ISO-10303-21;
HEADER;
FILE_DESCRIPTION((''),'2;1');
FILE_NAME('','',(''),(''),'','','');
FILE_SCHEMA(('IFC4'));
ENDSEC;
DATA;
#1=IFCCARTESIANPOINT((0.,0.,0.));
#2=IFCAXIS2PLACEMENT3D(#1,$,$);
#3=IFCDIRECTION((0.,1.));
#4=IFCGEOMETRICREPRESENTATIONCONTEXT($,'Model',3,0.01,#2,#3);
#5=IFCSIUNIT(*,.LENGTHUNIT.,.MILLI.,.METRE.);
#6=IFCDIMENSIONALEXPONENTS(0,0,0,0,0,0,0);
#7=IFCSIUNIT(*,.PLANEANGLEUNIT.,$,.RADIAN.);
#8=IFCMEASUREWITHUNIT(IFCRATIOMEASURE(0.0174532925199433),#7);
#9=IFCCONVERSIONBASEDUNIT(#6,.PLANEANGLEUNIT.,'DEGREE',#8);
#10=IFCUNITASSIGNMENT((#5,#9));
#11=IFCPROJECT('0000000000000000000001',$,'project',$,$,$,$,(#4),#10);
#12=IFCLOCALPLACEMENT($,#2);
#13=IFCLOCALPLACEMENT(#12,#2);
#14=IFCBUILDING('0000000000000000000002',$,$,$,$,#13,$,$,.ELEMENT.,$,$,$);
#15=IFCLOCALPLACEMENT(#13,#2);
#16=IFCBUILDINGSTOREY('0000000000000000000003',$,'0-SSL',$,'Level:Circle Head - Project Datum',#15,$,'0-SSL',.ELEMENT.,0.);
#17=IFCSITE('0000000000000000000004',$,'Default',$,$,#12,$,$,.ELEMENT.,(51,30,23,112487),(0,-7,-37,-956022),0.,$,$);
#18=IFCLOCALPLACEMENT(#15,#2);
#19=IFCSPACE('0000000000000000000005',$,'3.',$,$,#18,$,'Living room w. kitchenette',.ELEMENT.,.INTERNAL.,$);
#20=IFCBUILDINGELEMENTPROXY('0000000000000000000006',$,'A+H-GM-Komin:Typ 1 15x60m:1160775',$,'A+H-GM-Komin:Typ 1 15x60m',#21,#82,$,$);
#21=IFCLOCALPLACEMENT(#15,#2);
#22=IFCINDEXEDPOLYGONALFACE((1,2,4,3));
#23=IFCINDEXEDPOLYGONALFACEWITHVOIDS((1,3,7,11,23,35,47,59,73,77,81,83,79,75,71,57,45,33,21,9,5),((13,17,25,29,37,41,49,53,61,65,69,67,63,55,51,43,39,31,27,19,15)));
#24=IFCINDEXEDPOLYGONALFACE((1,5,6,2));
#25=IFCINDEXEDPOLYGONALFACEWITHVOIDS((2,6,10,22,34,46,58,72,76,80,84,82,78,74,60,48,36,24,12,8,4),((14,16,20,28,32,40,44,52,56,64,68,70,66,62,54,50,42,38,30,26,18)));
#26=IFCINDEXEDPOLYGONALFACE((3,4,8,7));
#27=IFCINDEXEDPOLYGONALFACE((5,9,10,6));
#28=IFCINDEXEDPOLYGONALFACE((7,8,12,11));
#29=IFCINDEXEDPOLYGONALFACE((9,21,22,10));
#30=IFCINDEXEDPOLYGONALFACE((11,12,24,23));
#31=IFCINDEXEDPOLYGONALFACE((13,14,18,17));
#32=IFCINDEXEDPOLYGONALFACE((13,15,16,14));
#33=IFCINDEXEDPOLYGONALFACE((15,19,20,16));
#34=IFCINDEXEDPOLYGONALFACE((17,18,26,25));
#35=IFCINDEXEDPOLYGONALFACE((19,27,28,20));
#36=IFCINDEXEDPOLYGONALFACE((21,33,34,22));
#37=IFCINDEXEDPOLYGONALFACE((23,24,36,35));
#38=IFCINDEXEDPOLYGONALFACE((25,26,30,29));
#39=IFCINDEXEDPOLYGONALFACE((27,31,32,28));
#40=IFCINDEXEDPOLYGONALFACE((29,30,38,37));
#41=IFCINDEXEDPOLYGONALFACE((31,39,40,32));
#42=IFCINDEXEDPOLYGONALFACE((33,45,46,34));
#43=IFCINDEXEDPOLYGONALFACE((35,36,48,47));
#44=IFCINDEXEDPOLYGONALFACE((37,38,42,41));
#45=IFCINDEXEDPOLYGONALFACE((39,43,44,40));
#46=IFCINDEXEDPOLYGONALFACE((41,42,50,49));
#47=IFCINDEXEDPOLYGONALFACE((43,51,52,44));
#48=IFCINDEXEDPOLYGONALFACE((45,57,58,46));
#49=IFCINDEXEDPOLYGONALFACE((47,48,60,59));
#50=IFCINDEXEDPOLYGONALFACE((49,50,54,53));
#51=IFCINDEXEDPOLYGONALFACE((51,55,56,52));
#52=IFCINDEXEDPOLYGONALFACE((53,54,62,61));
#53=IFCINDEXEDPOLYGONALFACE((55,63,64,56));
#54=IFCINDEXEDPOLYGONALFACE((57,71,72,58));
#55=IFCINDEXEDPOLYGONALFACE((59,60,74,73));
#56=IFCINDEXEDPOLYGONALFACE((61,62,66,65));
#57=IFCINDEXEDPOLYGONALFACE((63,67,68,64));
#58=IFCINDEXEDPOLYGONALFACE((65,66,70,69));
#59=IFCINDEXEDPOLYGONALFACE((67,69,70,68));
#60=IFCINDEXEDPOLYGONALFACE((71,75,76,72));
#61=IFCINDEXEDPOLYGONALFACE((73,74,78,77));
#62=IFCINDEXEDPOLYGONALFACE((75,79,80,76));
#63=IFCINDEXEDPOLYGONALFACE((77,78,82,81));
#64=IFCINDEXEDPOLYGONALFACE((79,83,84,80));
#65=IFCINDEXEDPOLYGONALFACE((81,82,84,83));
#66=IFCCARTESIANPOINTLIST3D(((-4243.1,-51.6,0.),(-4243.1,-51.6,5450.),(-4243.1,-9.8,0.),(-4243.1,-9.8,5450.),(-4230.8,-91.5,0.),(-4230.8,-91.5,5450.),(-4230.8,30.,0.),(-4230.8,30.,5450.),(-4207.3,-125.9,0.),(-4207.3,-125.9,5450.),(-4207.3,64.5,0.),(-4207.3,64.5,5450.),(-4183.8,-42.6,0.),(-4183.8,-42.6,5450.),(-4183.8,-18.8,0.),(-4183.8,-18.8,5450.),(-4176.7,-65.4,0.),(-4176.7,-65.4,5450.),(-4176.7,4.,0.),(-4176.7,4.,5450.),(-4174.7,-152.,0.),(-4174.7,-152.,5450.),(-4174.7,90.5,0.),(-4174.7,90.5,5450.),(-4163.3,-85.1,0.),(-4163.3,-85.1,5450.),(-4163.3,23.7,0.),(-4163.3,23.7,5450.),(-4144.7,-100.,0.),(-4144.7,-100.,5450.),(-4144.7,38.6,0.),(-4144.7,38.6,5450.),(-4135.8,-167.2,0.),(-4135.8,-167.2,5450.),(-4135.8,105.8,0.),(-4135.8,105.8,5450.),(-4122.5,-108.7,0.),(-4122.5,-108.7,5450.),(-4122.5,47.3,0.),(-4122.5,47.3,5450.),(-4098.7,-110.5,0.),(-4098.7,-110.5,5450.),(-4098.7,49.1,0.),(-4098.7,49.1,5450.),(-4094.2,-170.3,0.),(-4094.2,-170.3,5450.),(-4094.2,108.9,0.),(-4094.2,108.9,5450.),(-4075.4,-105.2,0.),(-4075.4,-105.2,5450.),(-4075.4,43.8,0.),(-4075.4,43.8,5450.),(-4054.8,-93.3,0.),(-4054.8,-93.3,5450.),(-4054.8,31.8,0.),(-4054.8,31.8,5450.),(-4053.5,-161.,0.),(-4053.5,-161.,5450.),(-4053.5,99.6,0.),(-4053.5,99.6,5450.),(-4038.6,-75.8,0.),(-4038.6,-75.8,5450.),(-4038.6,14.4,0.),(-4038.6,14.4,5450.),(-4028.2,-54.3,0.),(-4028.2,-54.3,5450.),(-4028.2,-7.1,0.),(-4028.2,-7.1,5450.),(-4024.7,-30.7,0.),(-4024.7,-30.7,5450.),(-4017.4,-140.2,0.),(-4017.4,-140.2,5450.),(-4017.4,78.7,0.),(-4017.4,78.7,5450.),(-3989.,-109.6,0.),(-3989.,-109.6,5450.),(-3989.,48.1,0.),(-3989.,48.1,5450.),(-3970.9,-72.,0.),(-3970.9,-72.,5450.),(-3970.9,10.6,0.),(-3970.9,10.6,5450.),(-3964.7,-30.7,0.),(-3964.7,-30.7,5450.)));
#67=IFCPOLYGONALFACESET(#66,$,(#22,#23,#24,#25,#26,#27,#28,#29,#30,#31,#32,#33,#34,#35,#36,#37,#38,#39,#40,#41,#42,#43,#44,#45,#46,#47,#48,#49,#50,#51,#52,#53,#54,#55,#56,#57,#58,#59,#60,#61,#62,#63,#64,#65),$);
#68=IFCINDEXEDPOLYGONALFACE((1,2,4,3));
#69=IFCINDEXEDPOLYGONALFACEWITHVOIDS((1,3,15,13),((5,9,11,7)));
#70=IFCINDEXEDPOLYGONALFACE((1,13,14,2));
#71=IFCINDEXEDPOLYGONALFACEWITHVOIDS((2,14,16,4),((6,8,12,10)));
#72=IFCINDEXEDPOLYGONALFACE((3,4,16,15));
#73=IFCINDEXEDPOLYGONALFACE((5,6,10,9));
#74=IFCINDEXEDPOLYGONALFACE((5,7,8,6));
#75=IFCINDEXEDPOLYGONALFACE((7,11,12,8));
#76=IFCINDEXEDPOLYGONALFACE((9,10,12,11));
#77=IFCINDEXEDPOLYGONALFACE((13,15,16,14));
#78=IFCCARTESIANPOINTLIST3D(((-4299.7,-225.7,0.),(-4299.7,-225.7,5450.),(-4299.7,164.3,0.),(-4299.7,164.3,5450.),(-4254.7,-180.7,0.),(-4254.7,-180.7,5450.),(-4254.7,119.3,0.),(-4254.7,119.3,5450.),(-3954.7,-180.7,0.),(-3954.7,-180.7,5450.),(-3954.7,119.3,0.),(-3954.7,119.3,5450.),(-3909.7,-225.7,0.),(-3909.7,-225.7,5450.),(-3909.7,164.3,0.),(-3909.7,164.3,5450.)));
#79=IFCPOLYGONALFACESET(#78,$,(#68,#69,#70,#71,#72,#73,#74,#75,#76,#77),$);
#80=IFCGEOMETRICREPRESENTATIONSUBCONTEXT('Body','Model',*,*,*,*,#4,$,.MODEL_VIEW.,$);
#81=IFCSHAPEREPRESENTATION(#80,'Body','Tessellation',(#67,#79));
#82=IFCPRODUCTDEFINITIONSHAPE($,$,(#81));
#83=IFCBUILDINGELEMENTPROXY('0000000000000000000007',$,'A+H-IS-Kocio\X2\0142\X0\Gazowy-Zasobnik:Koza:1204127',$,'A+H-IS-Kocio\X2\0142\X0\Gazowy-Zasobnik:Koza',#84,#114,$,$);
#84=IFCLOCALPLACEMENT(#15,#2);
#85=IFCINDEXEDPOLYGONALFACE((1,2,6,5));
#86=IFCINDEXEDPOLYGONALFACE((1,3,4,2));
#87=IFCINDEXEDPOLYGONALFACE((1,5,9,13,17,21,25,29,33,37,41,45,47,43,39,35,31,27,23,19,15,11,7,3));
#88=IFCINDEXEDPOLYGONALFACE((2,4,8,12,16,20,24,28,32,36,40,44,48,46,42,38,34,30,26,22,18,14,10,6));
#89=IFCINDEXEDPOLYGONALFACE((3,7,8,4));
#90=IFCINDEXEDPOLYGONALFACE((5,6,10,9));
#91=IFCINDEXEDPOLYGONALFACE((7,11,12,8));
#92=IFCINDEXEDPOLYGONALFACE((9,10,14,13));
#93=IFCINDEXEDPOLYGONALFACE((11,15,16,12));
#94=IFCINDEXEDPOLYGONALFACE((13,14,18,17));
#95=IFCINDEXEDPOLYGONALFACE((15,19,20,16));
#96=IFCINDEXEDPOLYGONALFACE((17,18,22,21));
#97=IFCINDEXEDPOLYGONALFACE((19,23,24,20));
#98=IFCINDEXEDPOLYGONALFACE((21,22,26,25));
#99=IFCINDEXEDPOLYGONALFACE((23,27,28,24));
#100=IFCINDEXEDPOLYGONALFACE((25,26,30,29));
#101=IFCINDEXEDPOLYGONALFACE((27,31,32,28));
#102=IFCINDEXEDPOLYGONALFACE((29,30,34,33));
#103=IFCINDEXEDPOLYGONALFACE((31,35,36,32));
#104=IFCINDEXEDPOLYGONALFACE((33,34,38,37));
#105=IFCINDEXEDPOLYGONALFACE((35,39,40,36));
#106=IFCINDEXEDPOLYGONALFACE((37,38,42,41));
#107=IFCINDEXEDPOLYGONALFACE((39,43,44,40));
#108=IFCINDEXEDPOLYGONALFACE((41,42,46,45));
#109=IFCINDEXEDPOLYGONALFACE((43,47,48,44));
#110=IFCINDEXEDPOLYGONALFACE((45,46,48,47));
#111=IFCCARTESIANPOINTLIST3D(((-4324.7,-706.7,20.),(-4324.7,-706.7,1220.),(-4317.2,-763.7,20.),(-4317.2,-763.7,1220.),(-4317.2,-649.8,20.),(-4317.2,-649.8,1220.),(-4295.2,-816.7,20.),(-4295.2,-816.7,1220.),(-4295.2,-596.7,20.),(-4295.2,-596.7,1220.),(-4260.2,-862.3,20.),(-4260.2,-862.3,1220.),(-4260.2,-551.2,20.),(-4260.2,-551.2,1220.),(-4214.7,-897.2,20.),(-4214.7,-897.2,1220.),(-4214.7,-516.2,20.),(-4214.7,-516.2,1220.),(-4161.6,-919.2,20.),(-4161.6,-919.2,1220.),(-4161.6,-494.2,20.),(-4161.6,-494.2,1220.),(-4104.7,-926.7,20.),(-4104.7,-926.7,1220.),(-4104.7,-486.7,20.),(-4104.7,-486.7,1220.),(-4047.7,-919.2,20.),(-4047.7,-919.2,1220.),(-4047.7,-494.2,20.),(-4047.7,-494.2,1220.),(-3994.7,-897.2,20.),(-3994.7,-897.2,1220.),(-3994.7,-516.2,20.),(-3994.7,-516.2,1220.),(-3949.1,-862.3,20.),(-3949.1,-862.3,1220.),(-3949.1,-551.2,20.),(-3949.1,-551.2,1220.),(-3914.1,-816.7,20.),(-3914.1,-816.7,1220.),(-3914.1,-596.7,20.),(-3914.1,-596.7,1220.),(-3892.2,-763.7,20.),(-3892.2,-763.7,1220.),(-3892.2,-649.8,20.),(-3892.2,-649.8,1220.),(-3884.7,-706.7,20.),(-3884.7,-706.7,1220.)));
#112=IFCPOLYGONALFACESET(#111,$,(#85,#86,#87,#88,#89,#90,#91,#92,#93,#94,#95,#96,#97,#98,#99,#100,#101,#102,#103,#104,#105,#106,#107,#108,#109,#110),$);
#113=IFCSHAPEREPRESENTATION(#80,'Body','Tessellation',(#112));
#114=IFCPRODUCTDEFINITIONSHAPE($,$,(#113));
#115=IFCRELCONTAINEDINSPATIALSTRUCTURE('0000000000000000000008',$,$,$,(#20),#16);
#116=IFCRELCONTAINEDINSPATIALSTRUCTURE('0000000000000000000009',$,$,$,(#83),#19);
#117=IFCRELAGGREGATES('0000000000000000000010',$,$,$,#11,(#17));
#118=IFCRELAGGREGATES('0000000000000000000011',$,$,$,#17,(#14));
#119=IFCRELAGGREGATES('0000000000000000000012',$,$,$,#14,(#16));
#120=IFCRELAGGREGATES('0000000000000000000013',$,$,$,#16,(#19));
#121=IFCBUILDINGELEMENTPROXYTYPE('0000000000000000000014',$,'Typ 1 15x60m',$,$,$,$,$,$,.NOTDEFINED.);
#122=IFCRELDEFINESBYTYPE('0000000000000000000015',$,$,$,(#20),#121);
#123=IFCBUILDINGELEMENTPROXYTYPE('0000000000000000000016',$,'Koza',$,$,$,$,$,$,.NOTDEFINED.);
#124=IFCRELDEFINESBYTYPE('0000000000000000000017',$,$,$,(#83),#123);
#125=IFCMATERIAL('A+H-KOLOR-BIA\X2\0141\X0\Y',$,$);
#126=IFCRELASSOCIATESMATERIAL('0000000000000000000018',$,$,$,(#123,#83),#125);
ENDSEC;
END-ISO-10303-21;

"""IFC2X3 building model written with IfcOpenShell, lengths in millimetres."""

from ifc_helpers import new_model, entity, si_unit, converted_unit, direction, frame, frame_2d, origin, place, context, subcontext, project, spatial, polyline, circle, hollow_circle, outline, extrude, source, transform, mapped, material, type_object, type_shapes, element, save


model = new_model("IFC2X3")

# Units and contexts
model_context = context("Model", 3, precision=0.01, world=origin(), true_north=direction((0.0, 1.0)))
body_context = subcontext(model_context, "Body", "Model", "MODEL_VIEW")
ifc_project = project(units=[si_unit("LENGTHUNIT", "METRE", prefix="MILLI"), converted_unit("PLANEANGLEUNIT", "DEGREE", entity("IfcRatioMeasure", 0.0174532925199433), si_unit("PLANEANGLEUNIT", "RADIAN"), dimensions=[0, 0, 0, 0, 0, 0, 0])], contexts=[model_context])

# Site, building, storey
site_placement = place(None, origin())
site = spatial("IfcSite", under=ifc_project, at=site_placement, Name="Default", CompositionType="ELEMENT", RefLatitude=(51, 30, 23, 112487), RefLongitude=(0, -7, -37, -956022), RefElevation=0.0)
building_placement = place(site_placement, origin())
building = spatial("IfcBuilding", under=site, at=building_placement, CompositionType="ELEMENT")
storey_placement = place(building_placement, origin())
storey = spatial("IfcBuildingStorey", under=building, at=storey_placement, Name="0-SSL", ObjectType="Level:Circle Head - Project Datum", LongName="0-SSL", CompositionType="ELEMENT", Elevation=0.0)

# Shared definitions
space_placement = place(storey_placement, origin())
space = spatial("IfcSpace", under=storey, at=space_placement, Name="3.", LongName="Living room w. kitchenette", CompositionType="ELEMENT", InteriorOrExteriorSpace="INTERNAL")

# Shared definitions
ifc_material_1 = material(Name="A+H-KOLOR-BIAŁY")

# Building element proxies
building_element_proxy_type_1 = type_object("IfcBuildingElementProxyType", Name="Typ 1 15x60m", PredefinedType="NOTDEFINED")
shared_shape_1 = source(origin(), body_context, "Body", "SweptSolid", [
    extrude(hollow_circle(Radius=140.0, WallThickness=60.0, at=frame_2d((0.0, 0.0), x_axis=(1.0, 0.0))), origin(), (0.0, 0.0, 1.0), 5450.0),
    extrude(outline(polyline([(-195.0, -195.0), (195.0, -195.0), (195.0, 195.0), (-195.0, 195.0), (-195.0, -195.0)]), holes=[polyline([(-150.0, -150.0), (-150.0, 150.0), (150.0, 150.0), (150.0, -150.0), (-150.0, -150.0)])]), frame((0.0, 0.0, 0.0), z_axis=(0.0, 0.0, 1.0), x_axis=(-1.0, 0.0, 0.0)), (0.0, 0.0, 1.0), 5450.0),
])
type_shapes(building_element_proxy_type_1, [shared_shape_1])
proxy_1_placement = place(storey_placement, frame((-4104.7, -30.7, 0.0)))
element("IfcBuildingElementProxy", 1, at=proxy_1_placement, inside=storey, type_object=building_element_proxy_type_1, Name="A+H-GM-Komin:Typ 1 15x60m:1160775", ObjectType="A+H-GM-Komin:Typ 1 15x60m", context=body_context, shape_type="MappedRepresentation", body=[
    mapped(shared_shape_1, transform((0.0, 0.0, 0.0), scale=1.0)),
])
building_element_proxy_type_2 = type_object("IfcBuildingElementProxyType", Name="Koza", PredefinedType="NOTDEFINED", material=ifc_material_1)
shared_shape_2 = source(origin(), body_context, "Body", "SweptSolid", [
    extrude(circle(Radius=220.0, at=frame_2d((0.0, 0.0), x_axis=(1.0, 0.0))), origin(), (0.0, 0.0, 1.0), 1200.0),
])
type_shapes(building_element_proxy_type_2, [shared_shape_2])
proxy_2_placement = place(space_placement, frame((-4104.7, -706.7, 20.0)))
element("IfcBuildingElementProxy", 2, at=proxy_2_placement, inside=space, type_object=building_element_proxy_type_2, material=ifc_material_1, Name="A+H-IS-KociołGazowy-Zasobnik:Koza:1204127", ObjectType="A+H-IS-KociołGazowy-Zasobnik:Koza", context=body_context, shape_type="MappedRepresentation", body=[
    mapped(shared_shape_2, transform((0.0, 0.0, 0.0), scale=1.0)),
])

save(model, "model.ifc")
